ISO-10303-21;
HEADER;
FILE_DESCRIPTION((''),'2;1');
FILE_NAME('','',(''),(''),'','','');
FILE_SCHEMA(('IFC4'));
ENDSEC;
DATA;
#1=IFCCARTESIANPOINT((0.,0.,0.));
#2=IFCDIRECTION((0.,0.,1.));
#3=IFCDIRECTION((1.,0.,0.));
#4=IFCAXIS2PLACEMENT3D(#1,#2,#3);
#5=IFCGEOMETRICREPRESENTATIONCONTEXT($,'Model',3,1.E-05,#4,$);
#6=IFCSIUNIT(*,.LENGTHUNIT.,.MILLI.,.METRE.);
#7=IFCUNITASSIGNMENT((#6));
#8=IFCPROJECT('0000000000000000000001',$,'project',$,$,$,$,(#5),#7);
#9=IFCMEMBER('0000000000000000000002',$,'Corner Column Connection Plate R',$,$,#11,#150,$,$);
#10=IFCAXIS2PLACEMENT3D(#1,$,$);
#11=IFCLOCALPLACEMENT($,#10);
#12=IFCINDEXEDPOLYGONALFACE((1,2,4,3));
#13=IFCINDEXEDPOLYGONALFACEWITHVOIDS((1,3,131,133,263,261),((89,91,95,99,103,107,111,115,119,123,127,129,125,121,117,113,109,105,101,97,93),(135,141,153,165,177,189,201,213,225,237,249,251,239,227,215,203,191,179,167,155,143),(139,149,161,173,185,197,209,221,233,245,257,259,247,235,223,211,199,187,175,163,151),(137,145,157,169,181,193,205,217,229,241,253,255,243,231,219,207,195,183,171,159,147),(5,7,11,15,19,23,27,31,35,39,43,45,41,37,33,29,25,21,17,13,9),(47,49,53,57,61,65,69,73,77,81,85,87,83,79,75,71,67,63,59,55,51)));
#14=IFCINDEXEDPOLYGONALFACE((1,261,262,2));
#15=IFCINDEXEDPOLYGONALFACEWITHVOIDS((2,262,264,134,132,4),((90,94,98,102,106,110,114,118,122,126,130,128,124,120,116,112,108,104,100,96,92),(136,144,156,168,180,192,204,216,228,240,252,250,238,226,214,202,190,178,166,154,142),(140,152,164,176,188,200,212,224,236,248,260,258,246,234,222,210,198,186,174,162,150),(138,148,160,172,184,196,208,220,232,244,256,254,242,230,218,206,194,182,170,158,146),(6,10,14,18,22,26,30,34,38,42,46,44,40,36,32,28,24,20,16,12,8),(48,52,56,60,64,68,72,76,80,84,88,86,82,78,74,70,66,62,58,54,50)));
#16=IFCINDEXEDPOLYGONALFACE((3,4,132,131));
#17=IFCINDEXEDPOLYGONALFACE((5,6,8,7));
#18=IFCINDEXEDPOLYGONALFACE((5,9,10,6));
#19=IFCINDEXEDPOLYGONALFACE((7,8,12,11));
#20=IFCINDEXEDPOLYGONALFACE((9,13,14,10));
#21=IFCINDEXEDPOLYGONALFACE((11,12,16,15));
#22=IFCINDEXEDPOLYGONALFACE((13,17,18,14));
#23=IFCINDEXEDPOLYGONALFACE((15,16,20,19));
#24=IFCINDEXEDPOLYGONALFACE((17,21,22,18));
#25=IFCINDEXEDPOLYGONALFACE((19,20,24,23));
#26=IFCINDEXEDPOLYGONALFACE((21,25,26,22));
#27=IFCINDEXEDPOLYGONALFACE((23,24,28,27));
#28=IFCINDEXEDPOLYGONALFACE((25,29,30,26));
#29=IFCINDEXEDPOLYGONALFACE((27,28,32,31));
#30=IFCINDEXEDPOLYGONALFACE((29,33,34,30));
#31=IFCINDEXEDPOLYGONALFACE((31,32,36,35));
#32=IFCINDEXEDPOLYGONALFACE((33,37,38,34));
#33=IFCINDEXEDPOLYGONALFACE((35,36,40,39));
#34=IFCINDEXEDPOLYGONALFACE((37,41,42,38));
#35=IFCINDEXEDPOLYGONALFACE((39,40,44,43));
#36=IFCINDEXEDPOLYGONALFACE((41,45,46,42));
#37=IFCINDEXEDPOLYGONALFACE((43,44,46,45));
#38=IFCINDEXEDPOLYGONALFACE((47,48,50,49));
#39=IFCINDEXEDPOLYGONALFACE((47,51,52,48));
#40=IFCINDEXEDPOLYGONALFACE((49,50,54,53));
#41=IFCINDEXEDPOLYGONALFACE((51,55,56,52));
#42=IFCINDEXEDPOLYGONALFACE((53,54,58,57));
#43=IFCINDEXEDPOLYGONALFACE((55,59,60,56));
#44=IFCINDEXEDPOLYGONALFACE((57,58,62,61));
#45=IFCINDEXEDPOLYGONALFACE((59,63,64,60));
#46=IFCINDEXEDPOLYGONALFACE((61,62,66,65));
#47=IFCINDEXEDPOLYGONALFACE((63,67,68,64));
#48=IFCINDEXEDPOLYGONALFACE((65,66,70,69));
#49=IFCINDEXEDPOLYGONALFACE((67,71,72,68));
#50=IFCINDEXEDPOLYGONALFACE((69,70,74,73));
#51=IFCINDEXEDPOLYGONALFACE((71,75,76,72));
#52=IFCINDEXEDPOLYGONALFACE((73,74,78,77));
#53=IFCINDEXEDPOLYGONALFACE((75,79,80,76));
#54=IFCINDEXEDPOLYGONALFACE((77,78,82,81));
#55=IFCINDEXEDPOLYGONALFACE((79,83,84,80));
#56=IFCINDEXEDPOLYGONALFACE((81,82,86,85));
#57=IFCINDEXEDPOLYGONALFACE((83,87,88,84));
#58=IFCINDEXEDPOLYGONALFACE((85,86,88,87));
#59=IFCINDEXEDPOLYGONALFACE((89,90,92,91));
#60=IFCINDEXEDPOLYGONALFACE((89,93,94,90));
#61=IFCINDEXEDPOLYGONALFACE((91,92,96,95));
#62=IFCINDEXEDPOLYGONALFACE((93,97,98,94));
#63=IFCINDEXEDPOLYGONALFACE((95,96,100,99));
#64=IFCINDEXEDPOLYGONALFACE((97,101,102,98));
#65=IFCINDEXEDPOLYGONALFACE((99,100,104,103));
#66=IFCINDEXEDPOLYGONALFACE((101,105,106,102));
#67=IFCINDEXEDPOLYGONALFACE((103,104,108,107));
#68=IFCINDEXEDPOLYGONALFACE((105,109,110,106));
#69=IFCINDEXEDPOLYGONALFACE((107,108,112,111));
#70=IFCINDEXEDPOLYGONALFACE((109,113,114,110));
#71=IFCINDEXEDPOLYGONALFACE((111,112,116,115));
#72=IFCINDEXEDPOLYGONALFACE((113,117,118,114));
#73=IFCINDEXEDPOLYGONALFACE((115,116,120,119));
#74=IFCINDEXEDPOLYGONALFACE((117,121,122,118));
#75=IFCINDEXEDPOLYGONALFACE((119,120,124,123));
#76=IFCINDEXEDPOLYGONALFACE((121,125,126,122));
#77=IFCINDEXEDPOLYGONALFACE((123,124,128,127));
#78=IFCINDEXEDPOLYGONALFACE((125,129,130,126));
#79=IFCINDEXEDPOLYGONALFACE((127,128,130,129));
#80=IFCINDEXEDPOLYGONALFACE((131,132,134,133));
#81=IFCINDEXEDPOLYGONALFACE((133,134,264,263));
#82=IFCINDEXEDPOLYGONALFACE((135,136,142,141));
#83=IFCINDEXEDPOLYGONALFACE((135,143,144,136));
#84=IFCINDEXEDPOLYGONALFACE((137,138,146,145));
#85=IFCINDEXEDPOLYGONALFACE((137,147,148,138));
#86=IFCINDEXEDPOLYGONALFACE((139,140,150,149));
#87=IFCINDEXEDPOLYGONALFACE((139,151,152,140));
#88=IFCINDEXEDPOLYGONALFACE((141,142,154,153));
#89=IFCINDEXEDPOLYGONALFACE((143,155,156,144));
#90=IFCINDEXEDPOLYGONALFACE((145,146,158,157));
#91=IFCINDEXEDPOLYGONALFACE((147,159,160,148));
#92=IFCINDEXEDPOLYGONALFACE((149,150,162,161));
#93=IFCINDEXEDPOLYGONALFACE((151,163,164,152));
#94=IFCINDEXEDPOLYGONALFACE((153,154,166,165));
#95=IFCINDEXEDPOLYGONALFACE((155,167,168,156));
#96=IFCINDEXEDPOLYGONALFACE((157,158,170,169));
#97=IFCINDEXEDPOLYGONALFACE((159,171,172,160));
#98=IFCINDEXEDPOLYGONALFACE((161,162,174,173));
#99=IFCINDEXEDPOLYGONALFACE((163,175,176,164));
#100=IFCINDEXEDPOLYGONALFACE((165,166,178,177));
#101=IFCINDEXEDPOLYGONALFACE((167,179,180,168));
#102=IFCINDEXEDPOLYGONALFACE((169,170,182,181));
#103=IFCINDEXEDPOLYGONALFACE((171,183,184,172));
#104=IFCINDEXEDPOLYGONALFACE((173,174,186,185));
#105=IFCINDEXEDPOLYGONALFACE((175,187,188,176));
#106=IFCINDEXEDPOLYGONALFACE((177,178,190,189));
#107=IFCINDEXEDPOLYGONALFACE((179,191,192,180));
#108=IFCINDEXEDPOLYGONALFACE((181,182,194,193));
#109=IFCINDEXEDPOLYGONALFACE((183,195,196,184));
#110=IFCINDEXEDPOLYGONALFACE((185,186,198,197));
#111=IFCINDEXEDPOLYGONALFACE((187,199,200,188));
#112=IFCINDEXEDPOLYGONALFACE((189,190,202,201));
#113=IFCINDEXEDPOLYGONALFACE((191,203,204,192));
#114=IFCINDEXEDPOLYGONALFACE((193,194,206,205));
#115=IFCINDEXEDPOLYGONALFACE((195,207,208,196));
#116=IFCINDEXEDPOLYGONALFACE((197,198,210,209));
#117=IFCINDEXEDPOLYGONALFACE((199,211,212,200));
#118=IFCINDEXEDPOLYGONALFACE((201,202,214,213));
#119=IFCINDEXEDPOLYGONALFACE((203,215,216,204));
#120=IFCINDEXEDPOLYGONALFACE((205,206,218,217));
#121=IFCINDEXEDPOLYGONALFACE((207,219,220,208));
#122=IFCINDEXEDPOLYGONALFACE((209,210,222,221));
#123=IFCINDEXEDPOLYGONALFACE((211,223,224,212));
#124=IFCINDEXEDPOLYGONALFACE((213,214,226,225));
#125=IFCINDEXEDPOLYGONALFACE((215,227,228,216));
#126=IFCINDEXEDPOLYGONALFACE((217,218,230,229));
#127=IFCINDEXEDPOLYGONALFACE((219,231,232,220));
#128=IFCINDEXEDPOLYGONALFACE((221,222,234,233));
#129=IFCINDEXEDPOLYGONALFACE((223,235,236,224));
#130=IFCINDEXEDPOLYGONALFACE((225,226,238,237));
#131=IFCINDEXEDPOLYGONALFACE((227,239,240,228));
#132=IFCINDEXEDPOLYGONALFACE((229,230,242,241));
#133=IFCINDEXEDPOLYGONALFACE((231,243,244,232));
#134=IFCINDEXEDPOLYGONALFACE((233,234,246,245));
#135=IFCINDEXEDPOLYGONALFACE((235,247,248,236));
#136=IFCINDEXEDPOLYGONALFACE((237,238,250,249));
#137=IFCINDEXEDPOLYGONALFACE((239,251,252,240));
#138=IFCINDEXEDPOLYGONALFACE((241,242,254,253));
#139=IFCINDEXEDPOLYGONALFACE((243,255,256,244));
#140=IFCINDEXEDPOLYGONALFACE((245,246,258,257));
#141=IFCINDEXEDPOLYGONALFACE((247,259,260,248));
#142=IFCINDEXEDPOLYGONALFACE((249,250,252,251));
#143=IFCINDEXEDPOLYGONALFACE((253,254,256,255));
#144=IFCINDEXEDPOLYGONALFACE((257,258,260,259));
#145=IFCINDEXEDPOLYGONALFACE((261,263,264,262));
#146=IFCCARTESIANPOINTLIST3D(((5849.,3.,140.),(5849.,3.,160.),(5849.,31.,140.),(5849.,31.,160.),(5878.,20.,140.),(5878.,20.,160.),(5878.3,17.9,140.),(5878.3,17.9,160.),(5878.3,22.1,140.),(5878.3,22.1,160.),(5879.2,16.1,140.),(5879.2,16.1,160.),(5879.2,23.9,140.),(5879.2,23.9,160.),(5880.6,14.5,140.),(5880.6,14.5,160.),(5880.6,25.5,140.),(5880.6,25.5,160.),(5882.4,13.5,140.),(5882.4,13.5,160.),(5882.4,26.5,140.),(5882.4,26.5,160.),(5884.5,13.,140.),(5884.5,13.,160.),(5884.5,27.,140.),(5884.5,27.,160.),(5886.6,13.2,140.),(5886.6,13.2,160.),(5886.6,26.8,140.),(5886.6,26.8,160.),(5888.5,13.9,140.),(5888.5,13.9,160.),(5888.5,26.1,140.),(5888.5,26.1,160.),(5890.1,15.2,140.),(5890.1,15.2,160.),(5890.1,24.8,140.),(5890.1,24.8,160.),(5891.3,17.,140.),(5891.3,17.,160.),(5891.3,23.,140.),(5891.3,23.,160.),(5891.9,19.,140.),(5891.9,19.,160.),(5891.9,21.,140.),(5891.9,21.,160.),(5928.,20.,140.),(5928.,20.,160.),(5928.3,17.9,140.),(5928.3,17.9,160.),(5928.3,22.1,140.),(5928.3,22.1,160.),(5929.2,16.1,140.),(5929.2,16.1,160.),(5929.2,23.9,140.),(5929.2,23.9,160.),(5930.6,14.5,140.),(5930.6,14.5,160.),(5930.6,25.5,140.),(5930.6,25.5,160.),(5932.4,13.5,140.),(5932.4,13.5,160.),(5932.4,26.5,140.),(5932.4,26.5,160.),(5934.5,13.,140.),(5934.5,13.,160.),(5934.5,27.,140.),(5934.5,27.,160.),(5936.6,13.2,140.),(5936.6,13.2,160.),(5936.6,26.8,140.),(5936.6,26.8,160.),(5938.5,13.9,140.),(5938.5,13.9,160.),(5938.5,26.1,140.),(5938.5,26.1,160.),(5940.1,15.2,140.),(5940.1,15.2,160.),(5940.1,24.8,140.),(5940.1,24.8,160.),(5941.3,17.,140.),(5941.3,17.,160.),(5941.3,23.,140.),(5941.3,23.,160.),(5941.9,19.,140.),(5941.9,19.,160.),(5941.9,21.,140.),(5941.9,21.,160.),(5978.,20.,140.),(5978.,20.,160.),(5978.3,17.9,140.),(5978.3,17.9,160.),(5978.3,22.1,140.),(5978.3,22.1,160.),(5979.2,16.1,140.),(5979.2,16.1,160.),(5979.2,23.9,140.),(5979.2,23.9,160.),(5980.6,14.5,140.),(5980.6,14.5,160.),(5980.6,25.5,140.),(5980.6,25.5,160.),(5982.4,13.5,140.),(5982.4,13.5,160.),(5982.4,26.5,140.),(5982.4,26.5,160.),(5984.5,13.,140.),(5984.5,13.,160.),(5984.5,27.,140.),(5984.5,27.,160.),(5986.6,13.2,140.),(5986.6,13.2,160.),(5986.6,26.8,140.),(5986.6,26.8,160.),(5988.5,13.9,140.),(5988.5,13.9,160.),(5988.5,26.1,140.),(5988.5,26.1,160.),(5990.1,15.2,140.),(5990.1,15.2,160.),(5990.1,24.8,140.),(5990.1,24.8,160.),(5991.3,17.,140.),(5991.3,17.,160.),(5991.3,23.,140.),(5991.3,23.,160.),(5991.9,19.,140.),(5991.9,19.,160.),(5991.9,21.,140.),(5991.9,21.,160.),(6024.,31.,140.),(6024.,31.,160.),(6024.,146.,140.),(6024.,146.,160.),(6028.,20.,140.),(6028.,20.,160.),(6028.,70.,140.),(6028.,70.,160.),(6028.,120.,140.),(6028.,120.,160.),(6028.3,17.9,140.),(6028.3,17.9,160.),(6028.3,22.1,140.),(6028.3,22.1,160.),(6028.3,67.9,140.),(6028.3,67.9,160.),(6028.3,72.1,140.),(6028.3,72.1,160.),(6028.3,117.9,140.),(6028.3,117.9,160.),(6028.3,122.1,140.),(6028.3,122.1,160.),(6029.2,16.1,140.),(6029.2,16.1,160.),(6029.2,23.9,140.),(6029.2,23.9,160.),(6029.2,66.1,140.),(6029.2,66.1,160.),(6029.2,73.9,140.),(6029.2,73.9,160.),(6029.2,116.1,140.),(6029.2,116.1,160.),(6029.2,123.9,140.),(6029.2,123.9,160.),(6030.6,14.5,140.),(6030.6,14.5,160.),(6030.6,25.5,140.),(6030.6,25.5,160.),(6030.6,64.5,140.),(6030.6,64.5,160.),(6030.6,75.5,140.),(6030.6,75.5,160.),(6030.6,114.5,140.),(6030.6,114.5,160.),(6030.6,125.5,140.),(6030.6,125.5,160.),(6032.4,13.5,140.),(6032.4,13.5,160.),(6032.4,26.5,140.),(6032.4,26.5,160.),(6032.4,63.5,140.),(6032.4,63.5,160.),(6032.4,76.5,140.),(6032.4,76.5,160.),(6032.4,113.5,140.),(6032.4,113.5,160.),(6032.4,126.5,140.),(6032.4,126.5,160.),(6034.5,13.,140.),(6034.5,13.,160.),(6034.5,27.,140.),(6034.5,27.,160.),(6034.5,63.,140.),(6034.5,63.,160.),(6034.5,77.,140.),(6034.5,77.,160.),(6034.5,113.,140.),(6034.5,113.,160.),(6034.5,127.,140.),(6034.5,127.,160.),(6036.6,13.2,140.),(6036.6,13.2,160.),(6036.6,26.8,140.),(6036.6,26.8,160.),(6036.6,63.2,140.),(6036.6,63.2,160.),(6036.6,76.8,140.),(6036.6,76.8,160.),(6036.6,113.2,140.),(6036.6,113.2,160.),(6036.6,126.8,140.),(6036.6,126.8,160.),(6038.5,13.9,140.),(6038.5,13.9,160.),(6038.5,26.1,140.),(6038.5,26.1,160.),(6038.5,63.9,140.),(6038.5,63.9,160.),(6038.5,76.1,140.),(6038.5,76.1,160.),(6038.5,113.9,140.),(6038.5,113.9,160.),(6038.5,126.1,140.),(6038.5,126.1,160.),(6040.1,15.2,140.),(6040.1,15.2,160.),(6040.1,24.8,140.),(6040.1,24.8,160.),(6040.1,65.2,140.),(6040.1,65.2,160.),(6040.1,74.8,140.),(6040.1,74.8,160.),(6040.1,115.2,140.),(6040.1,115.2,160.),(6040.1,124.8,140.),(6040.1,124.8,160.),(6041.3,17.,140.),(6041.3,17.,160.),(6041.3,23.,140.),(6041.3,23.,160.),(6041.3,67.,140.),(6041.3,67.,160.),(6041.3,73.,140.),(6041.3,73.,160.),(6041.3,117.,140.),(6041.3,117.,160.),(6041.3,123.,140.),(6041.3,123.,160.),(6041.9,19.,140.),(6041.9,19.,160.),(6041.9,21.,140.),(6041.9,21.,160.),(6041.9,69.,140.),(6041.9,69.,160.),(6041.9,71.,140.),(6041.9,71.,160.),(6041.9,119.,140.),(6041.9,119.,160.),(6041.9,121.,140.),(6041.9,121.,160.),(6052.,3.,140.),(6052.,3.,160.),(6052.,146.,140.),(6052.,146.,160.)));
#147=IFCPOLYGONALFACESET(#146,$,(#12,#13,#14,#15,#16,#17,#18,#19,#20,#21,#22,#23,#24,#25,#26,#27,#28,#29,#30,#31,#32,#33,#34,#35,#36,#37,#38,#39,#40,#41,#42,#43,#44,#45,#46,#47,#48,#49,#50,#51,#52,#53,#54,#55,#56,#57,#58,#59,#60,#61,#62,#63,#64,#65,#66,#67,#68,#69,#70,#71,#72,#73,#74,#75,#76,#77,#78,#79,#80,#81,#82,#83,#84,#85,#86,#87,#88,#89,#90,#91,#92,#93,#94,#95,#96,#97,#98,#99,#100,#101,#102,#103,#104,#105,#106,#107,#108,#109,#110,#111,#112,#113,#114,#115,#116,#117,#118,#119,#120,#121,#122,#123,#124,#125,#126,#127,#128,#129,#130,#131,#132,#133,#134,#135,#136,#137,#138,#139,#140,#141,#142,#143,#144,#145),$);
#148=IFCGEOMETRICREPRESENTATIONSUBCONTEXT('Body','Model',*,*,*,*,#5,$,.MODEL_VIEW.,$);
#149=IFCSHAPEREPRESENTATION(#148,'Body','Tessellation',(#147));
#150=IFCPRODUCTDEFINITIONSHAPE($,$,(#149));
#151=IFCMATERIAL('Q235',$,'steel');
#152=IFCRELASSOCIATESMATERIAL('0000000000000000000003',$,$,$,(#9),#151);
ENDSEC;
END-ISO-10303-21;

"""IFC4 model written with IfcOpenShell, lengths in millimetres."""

from ifc_helpers import new_model, si_unit, frame, origin_with_axes, origin_2d, place, context, subcontext, project, line, indexed_curve, circle_curve, outline, extrude, material, element, save


model = new_model("IFC4")

# Units and contexts
model_context = context("Model", 3, precision=1e-05, world=origin_with_axes())
body_context = subcontext(model_context, "Body", "Model", "MODEL_VIEW")
ifc_project = project(units=[si_unit("LENGTHUNIT", "METRE", prefix="MILLI")], contexts=[model_context])

# Member, openings
ifc_material_1 = material(Name="Q235", Category="steel")
member_1_placement = place(None, frame((6052.0, 3.0, 140.0), z_axis=(0.0, 0.0, 1.0), x_axis=(-1.0, 0.0, 0.0)))
member_1 = element("IfcMember", 1, at=member_1_placement, material=ifc_material_1, Name="Corner Column Connection Plate R", context=body_context, shape_type="SweptSolid", body=[
    extrude(outline(indexed_curve([(0.0, 0.0), (203.0, 0.0), (203.0, -28.0), (28.0, -28.0), (28.0, -143.0), (0.0, -143.0), (0.0, 0.0)], segments=[line(1, 2, 3, 4, 5, 6, 7, 1)])), origin_with_axes(), (0.0, 0.0, 1.0), 20.0),
])
opening_1_placement = place(member_1_placement, frame((17.0, -17.0, 0.0), z_axis=(0.0, 0.0, 1.0), x_axis=(1.0, 0.0, 0.0)))
element("IfcOpeningElement", 2, at=opening_1_placement, cuts=member_1, context=body_context, shape_type="SweptSolid", body=[
    extrude(outline(circle_curve(origin_2d(), 7.0)), origin_with_axes(), (0.0, 0.0, 1.0), 20.0),
])
opening_2_placement = place(member_1_placement, frame((67.0, -17.0, 0.0), z_axis=(0.0, 0.0, 1.0), x_axis=(1.0, 0.0, 0.0)))
element("IfcOpeningElement", 3, at=opening_2_placement, cuts=member_1, context=body_context, shape_type="SweptSolid", body=[
    extrude(outline(circle_curve(origin_2d(), 7.0)), origin_with_axes(), (0.0, 0.0, 1.0), 20.0),
])
opening_3_placement = place(member_1_placement, frame((117.0, -17.0, 0.0), z_axis=(0.0, 0.0, 1.0), x_axis=(1.0, 0.0, 0.0)))
element("IfcOpeningElement", 4, at=opening_3_placement, cuts=member_1, context=body_context, shape_type="SweptSolid", body=[
    extrude(outline(circle_curve(origin_2d(), 7.0)), origin_with_axes(), (0.0, 0.0, 1.0), 20.0),
])
opening_4_placement = place(member_1_placement, frame((167.0, -17.0, 0.0), z_axis=(0.0, 0.0, 1.0), x_axis=(1.0, 0.0, 0.0)))
element("IfcOpeningElement", 5, at=opening_4_placement, cuts=member_1, context=body_context, shape_type="SweptSolid", body=[
    extrude(outline(circle_curve(origin_2d(), 7.0)), origin_with_axes(), (0.0, 0.0, 1.0), 20.0),
])
opening_5_placement = place(member_1_placement, frame((17.0, -67.0, 0.0), z_axis=(0.0, 0.0, 1.0), x_axis=(1.0, 0.0, 0.0)))
element("IfcOpeningElement", 6, at=opening_5_placement, cuts=member_1, context=body_context, shape_type="SweptSolid", body=[
    extrude(outline(circle_curve(origin_2d(), 7.0)), origin_with_axes(), (0.0, 0.0, 1.0), 20.0),
])
opening_6_placement = place(member_1_placement, frame((17.0, -117.0, 0.0), z_axis=(0.0, 0.0, 1.0), x_axis=(1.0, 0.0, 0.0)))
element("IfcOpeningElement", 7, at=opening_6_placement, cuts=member_1, context=body_context, shape_type="SweptSolid", body=[
    extrude(outline(circle_curve(origin_2d(), 7.0)), origin_with_axes(), (0.0, 0.0, 1.0), 20.0),
])

save(model, "model.ifc")
